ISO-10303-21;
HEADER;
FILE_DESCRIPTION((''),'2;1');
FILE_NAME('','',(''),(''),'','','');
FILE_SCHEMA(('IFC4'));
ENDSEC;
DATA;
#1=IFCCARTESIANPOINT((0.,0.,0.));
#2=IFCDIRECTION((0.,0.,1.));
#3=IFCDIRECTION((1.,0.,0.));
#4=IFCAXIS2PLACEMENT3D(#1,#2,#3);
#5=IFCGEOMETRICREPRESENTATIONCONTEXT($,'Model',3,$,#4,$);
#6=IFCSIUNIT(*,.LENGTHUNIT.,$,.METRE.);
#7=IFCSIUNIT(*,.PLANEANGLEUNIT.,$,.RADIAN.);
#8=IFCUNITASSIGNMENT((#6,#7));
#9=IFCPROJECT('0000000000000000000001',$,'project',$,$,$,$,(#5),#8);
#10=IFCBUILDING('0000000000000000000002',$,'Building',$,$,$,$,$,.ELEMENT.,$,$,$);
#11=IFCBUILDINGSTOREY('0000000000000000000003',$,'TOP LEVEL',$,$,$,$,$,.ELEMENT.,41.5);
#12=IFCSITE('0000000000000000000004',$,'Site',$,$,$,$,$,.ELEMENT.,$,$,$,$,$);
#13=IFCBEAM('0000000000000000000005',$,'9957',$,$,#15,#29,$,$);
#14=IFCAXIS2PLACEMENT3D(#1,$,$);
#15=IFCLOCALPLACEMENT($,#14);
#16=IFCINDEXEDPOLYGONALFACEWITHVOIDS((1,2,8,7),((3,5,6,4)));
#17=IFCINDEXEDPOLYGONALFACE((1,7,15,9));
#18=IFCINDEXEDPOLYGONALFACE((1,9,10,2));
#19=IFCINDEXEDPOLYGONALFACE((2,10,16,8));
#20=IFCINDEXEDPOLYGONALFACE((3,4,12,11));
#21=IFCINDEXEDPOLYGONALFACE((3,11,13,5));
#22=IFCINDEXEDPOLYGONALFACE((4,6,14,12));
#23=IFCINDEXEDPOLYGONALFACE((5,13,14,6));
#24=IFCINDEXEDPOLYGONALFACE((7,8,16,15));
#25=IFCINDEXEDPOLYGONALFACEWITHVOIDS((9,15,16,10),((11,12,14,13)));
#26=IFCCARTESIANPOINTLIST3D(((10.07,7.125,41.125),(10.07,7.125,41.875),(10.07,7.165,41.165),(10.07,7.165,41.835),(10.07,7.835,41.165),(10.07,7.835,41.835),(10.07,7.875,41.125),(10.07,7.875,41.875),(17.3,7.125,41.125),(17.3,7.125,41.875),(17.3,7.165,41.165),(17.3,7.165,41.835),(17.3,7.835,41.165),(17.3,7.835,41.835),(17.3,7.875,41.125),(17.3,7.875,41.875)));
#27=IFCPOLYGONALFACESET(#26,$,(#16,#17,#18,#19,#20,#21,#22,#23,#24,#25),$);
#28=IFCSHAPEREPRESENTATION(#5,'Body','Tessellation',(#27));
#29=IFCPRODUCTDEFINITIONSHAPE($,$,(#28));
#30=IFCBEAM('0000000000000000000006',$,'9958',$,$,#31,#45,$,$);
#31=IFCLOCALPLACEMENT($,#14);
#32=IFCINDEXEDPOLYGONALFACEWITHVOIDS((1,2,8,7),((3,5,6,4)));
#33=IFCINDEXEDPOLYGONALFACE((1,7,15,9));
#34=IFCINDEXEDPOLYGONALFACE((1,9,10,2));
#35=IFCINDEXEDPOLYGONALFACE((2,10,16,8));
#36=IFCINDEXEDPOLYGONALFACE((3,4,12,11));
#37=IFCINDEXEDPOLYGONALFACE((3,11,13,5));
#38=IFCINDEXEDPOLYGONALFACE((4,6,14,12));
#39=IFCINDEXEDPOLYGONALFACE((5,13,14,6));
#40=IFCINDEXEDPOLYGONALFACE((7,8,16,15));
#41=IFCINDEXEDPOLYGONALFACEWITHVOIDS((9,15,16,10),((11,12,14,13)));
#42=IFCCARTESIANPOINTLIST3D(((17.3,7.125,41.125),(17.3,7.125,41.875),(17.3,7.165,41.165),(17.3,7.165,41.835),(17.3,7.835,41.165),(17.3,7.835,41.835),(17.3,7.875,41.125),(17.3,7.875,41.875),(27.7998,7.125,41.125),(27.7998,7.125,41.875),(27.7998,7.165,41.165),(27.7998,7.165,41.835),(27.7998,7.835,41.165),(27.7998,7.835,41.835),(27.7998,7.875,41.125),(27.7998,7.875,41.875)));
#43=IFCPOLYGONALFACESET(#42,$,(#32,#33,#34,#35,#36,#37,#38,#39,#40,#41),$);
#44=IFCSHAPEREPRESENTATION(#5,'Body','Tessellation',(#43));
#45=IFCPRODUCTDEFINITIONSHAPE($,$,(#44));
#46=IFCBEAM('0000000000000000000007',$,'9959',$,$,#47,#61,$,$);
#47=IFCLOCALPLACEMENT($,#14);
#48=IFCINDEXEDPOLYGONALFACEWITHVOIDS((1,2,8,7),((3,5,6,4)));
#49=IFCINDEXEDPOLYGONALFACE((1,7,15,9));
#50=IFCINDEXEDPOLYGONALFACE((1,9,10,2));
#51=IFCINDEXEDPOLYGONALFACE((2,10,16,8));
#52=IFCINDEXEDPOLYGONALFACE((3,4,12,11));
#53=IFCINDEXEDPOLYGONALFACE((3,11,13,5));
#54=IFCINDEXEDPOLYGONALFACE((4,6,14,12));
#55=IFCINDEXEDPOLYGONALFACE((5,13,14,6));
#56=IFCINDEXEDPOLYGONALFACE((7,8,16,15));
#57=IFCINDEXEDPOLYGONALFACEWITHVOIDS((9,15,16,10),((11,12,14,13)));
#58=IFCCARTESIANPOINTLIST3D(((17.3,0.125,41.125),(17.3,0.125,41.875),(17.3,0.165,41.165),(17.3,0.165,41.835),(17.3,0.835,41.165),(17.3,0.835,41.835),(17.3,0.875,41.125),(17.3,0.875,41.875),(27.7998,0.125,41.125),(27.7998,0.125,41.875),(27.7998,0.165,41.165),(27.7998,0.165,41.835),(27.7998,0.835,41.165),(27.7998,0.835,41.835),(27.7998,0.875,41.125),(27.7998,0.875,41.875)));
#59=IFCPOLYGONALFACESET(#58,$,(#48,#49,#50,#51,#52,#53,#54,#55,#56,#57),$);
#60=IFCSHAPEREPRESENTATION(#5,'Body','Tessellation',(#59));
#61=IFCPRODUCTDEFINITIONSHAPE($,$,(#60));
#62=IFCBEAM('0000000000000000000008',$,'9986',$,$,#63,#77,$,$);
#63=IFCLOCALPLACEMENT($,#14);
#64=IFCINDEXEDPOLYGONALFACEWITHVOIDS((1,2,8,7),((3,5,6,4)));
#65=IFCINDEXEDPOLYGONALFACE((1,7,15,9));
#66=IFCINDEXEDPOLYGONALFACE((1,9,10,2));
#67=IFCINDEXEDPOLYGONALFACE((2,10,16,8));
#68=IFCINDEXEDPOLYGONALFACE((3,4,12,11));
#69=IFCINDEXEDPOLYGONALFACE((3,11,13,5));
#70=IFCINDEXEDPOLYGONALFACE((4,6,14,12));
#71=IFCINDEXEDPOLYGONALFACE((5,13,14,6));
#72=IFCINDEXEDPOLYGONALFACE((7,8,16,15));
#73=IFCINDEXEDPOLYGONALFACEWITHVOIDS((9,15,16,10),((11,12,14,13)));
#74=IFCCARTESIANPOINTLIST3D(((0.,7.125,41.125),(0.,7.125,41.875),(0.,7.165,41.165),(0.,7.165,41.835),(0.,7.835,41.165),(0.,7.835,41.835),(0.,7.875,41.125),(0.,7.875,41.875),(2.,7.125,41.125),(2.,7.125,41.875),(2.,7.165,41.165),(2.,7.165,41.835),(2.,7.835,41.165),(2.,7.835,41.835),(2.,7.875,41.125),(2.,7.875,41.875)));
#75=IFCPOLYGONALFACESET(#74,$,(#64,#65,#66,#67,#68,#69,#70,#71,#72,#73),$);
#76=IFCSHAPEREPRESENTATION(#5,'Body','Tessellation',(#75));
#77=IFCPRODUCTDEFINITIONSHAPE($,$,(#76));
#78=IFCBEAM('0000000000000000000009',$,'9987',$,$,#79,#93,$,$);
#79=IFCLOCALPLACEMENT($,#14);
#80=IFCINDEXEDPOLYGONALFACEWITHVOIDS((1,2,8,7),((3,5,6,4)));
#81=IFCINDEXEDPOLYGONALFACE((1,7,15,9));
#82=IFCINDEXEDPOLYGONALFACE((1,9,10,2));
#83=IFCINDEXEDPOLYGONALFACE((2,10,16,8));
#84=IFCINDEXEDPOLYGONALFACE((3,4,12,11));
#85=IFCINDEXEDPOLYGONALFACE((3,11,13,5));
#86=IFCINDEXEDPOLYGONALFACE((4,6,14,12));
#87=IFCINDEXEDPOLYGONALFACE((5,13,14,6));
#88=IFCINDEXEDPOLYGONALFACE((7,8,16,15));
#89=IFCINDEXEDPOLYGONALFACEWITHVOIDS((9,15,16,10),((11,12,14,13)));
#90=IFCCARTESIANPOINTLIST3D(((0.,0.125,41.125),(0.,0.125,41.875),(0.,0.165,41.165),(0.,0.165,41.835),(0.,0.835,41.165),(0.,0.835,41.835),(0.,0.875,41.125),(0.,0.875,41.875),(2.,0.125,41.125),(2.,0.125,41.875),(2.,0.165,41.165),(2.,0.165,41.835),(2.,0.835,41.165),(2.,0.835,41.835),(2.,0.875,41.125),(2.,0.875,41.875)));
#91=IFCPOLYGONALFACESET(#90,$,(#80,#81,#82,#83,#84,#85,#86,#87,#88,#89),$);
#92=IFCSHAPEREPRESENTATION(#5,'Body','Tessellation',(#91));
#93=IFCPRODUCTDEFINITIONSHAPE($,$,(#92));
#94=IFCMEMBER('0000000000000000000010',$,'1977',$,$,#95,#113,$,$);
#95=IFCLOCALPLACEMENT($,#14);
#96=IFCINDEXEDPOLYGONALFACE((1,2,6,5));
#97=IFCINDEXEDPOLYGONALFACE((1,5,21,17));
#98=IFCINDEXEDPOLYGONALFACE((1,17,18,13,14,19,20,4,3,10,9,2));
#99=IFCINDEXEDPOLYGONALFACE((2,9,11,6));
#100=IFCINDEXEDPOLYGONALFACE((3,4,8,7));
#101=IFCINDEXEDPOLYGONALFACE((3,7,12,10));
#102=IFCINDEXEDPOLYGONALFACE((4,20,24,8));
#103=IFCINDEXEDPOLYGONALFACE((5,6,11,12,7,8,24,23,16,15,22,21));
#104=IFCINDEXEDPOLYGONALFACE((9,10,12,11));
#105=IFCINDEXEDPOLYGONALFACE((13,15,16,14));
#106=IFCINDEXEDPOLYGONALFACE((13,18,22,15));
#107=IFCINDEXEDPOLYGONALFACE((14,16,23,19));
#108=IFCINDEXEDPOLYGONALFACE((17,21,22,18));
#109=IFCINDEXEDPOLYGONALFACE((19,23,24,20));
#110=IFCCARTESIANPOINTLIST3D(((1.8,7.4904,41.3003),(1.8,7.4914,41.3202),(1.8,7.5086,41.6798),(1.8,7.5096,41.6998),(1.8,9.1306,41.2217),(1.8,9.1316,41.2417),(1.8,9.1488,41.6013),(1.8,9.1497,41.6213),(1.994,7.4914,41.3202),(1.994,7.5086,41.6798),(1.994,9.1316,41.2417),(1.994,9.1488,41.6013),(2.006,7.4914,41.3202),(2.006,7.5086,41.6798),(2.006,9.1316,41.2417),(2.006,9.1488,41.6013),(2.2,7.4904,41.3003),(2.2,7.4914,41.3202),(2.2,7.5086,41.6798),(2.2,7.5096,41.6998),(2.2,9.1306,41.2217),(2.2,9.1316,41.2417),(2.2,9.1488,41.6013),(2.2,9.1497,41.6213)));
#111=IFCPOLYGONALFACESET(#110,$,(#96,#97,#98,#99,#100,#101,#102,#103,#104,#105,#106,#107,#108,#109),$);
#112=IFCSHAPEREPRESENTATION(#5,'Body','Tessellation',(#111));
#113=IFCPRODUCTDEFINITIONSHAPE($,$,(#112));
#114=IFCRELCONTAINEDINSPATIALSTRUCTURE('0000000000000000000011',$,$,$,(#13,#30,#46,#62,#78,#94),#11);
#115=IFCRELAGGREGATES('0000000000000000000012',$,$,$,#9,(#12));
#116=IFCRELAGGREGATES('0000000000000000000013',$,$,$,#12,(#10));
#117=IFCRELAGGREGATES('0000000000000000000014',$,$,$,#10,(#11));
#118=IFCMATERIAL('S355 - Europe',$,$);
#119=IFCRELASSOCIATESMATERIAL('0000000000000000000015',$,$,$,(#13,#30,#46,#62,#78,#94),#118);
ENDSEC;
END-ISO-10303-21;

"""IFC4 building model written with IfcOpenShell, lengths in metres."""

from ifc_helpers import new_model, si_unit, frame, origin_with_axes, origin_2d_with_axis, place, context, project, spatial, hollow_rectangle, i_section, extrude, material, material_profile, profile_set, profile_usage, element, save


model = new_model("IFC4")

# Units and contexts
model_context = context("Model", 3, world=origin_with_axes())
ifc_project = project(units=[si_unit("LENGTHUNIT", "METRE"), si_unit("PLANEANGLEUNIT", "RADIAN")], contexts=[model_context])

# Site, building, storey
site = spatial("IfcSite", under=ifc_project, Name="Site", CompositionType="ELEMENT")
building = spatial("IfcBuilding", under=site, Name="Building", CompositionType="ELEMENT")
storey = spatial("IfcBuildingStorey", under=building, Name="TOP LEVEL", CompositionType="ELEMENT", Elevation=41.5)

# Beams
ifc_material = material(Name="S355 - Europe")
ifc_material_profile_1 = material_profile(ifc_material, hollow_rectangle(XDim=0.75, YDim=0.75, WallThickness=0.04, at=origin_2d_with_axis()))
ifc_profile_set_1 = profile_set([ifc_material_profile_1])
ifc_profile_usage_1 = profile_usage(ifc_profile_set_1, cardinal=10)
beam_1_placement = place(None, frame((17.3, 7.5, 41.5), z_axis=(-1.0, 0.0, 0.0), x_axis=(0.0, -1.0, 0.0)))
element("IfcBeam", 1, at=beam_1_placement, inside=storey, material=ifc_profile_usage_1, Name="9957", context=model_context, shape_type="SweptSolid", body=[
    extrude(hollow_rectangle(XDim=0.75, YDim=0.75, WallThickness=0.04, at=origin_2d_with_axis()), origin_with_axes(), (0.0, 0.0, 1.0), 7.23),
])
ifc_material_profile_2 = material_profile(ifc_material, hollow_rectangle(XDim=0.75, YDim=0.75, WallThickness=0.04, at=origin_2d_with_axis()))
ifc_profile_set_2 = profile_set([ifc_material_profile_2])
ifc_profile_usage_2 = profile_usage(ifc_profile_set_2, cardinal=10)
beam_2_placement = place(None, frame((27.7998, 7.5, 41.5), z_axis=(-1.0, 0.0, 0.0), x_axis=(0.0, -1.0, 0.0)))
element("IfcBeam", 2, at=beam_2_placement, inside=storey, material=ifc_profile_usage_2, Name="9958", context=model_context, shape_type="SweptSolid", body=[
    extrude(hollow_rectangle(XDim=0.75, YDim=0.75, WallThickness=0.04, at=origin_2d_with_axis()), origin_with_axes(), (0.0, 0.0, 1.0), 10.4998),
])
ifc_material_profile_3 = material_profile(ifc_material, hollow_rectangle(XDim=0.75, YDim=0.75, WallThickness=0.04, at=origin_2d_with_axis()))
ifc_profile_set_3 = profile_set([ifc_material_profile_3])
ifc_profile_usage_3 = profile_usage(ifc_profile_set_3, cardinal=10)
beam_3_placement = place(None, frame((27.7998, 0.5, 41.5), z_axis=(-1.0, 0.0, 0.0), x_axis=(0.0, -1.0, 0.0)))
element("IfcBeam", 3, at=beam_3_placement, inside=storey, material=ifc_profile_usage_3, Name="9959", context=model_context, shape_type="SweptSolid", body=[
    extrude(hollow_rectangle(XDim=0.75, YDim=0.75, WallThickness=0.04, at=origin_2d_with_axis()), origin_with_axes(), (0.0, 0.0, 1.0), 10.4998),
])
ifc_material_profile_4 = material_profile(ifc_material, hollow_rectangle(XDim=0.75, YDim=0.75, WallThickness=0.04, at=origin_2d_with_axis()))
ifc_profile_set_4 = profile_set([ifc_material_profile_4])
ifc_profile_usage_4 = profile_usage(ifc_profile_set_4, cardinal=10)
beam_4_placement = place(None, frame((2.0, 7.5, 41.5), z_axis=(-1.0, 0.0, 0.0), x_axis=(0.0, -1.0, 0.0)))
element("IfcBeam", 4, at=beam_4_placement, inside=storey, material=ifc_profile_usage_4, Name="9986", context=model_context, shape_type="SweptSolid", body=[
    extrude(hollow_rectangle(XDim=0.75, YDim=0.75, WallThickness=0.04, at=origin_2d_with_axis()), origin_with_axes(), (0.0, 0.0, 1.0), 2.0),
])
ifc_material_profile_5 = material_profile(ifc_material, hollow_rectangle(XDim=0.75, YDim=0.75, WallThickness=0.04, at=origin_2d_with_axis()))
ifc_profile_set_5 = profile_set([ifc_material_profile_5])
ifc_profile_usage_5 = profile_usage(ifc_profile_set_5, cardinal=10)
beam_5_placement = place(None, frame((2.0, 0.5, 41.5), z_axis=(-1.0, 0.0, 0.0), x_axis=(0.0, -1.0, 0.0)))
element("IfcBeam", 5, at=beam_5_placement, inside=storey, material=ifc_profile_usage_5, Name="9987", context=model_context, shape_type="SweptSolid", body=[
    extrude(hollow_rectangle(XDim=0.75, YDim=0.75, WallThickness=0.04, at=origin_2d_with_axis()), origin_with_axes(), (0.0, 0.0, 1.0), 2.0),
])

# Member
ifc_material_profile_6 = material_profile(ifc_material, i_section(OverallWidth=0.4, OverallDepth=0.4, WebThickness=0.012, FlangeThickness=0.02, at=origin_2d_with_axis()))
ifc_profile_set_6 = profile_set([ifc_material_profile_6])
ifc_profile_usage_6 = profile_usage(ifc_profile_set_6, cardinal=10)
member_placement = place(None, frame((2.0, 9.1402, 41.4215), z_axis=(0.0, -0.998856, 0.047828), x_axis=(1.0, 0.0, 0.0)))
element("IfcMember", 6, at=member_placement, inside=storey, material=ifc_profile_usage_6, Name="1977", context=model_context, shape_type="SweptSolid", body=[
    extrude(i_section(OverallWidth=0.4, OverallDepth=0.4, WebThickness=0.012, FlangeThickness=0.02, at=origin_2d_with_axis()), origin_with_axes(), (0.0, 0.0, 1.0), 1.642),
])

save(model, "model.ifc")
